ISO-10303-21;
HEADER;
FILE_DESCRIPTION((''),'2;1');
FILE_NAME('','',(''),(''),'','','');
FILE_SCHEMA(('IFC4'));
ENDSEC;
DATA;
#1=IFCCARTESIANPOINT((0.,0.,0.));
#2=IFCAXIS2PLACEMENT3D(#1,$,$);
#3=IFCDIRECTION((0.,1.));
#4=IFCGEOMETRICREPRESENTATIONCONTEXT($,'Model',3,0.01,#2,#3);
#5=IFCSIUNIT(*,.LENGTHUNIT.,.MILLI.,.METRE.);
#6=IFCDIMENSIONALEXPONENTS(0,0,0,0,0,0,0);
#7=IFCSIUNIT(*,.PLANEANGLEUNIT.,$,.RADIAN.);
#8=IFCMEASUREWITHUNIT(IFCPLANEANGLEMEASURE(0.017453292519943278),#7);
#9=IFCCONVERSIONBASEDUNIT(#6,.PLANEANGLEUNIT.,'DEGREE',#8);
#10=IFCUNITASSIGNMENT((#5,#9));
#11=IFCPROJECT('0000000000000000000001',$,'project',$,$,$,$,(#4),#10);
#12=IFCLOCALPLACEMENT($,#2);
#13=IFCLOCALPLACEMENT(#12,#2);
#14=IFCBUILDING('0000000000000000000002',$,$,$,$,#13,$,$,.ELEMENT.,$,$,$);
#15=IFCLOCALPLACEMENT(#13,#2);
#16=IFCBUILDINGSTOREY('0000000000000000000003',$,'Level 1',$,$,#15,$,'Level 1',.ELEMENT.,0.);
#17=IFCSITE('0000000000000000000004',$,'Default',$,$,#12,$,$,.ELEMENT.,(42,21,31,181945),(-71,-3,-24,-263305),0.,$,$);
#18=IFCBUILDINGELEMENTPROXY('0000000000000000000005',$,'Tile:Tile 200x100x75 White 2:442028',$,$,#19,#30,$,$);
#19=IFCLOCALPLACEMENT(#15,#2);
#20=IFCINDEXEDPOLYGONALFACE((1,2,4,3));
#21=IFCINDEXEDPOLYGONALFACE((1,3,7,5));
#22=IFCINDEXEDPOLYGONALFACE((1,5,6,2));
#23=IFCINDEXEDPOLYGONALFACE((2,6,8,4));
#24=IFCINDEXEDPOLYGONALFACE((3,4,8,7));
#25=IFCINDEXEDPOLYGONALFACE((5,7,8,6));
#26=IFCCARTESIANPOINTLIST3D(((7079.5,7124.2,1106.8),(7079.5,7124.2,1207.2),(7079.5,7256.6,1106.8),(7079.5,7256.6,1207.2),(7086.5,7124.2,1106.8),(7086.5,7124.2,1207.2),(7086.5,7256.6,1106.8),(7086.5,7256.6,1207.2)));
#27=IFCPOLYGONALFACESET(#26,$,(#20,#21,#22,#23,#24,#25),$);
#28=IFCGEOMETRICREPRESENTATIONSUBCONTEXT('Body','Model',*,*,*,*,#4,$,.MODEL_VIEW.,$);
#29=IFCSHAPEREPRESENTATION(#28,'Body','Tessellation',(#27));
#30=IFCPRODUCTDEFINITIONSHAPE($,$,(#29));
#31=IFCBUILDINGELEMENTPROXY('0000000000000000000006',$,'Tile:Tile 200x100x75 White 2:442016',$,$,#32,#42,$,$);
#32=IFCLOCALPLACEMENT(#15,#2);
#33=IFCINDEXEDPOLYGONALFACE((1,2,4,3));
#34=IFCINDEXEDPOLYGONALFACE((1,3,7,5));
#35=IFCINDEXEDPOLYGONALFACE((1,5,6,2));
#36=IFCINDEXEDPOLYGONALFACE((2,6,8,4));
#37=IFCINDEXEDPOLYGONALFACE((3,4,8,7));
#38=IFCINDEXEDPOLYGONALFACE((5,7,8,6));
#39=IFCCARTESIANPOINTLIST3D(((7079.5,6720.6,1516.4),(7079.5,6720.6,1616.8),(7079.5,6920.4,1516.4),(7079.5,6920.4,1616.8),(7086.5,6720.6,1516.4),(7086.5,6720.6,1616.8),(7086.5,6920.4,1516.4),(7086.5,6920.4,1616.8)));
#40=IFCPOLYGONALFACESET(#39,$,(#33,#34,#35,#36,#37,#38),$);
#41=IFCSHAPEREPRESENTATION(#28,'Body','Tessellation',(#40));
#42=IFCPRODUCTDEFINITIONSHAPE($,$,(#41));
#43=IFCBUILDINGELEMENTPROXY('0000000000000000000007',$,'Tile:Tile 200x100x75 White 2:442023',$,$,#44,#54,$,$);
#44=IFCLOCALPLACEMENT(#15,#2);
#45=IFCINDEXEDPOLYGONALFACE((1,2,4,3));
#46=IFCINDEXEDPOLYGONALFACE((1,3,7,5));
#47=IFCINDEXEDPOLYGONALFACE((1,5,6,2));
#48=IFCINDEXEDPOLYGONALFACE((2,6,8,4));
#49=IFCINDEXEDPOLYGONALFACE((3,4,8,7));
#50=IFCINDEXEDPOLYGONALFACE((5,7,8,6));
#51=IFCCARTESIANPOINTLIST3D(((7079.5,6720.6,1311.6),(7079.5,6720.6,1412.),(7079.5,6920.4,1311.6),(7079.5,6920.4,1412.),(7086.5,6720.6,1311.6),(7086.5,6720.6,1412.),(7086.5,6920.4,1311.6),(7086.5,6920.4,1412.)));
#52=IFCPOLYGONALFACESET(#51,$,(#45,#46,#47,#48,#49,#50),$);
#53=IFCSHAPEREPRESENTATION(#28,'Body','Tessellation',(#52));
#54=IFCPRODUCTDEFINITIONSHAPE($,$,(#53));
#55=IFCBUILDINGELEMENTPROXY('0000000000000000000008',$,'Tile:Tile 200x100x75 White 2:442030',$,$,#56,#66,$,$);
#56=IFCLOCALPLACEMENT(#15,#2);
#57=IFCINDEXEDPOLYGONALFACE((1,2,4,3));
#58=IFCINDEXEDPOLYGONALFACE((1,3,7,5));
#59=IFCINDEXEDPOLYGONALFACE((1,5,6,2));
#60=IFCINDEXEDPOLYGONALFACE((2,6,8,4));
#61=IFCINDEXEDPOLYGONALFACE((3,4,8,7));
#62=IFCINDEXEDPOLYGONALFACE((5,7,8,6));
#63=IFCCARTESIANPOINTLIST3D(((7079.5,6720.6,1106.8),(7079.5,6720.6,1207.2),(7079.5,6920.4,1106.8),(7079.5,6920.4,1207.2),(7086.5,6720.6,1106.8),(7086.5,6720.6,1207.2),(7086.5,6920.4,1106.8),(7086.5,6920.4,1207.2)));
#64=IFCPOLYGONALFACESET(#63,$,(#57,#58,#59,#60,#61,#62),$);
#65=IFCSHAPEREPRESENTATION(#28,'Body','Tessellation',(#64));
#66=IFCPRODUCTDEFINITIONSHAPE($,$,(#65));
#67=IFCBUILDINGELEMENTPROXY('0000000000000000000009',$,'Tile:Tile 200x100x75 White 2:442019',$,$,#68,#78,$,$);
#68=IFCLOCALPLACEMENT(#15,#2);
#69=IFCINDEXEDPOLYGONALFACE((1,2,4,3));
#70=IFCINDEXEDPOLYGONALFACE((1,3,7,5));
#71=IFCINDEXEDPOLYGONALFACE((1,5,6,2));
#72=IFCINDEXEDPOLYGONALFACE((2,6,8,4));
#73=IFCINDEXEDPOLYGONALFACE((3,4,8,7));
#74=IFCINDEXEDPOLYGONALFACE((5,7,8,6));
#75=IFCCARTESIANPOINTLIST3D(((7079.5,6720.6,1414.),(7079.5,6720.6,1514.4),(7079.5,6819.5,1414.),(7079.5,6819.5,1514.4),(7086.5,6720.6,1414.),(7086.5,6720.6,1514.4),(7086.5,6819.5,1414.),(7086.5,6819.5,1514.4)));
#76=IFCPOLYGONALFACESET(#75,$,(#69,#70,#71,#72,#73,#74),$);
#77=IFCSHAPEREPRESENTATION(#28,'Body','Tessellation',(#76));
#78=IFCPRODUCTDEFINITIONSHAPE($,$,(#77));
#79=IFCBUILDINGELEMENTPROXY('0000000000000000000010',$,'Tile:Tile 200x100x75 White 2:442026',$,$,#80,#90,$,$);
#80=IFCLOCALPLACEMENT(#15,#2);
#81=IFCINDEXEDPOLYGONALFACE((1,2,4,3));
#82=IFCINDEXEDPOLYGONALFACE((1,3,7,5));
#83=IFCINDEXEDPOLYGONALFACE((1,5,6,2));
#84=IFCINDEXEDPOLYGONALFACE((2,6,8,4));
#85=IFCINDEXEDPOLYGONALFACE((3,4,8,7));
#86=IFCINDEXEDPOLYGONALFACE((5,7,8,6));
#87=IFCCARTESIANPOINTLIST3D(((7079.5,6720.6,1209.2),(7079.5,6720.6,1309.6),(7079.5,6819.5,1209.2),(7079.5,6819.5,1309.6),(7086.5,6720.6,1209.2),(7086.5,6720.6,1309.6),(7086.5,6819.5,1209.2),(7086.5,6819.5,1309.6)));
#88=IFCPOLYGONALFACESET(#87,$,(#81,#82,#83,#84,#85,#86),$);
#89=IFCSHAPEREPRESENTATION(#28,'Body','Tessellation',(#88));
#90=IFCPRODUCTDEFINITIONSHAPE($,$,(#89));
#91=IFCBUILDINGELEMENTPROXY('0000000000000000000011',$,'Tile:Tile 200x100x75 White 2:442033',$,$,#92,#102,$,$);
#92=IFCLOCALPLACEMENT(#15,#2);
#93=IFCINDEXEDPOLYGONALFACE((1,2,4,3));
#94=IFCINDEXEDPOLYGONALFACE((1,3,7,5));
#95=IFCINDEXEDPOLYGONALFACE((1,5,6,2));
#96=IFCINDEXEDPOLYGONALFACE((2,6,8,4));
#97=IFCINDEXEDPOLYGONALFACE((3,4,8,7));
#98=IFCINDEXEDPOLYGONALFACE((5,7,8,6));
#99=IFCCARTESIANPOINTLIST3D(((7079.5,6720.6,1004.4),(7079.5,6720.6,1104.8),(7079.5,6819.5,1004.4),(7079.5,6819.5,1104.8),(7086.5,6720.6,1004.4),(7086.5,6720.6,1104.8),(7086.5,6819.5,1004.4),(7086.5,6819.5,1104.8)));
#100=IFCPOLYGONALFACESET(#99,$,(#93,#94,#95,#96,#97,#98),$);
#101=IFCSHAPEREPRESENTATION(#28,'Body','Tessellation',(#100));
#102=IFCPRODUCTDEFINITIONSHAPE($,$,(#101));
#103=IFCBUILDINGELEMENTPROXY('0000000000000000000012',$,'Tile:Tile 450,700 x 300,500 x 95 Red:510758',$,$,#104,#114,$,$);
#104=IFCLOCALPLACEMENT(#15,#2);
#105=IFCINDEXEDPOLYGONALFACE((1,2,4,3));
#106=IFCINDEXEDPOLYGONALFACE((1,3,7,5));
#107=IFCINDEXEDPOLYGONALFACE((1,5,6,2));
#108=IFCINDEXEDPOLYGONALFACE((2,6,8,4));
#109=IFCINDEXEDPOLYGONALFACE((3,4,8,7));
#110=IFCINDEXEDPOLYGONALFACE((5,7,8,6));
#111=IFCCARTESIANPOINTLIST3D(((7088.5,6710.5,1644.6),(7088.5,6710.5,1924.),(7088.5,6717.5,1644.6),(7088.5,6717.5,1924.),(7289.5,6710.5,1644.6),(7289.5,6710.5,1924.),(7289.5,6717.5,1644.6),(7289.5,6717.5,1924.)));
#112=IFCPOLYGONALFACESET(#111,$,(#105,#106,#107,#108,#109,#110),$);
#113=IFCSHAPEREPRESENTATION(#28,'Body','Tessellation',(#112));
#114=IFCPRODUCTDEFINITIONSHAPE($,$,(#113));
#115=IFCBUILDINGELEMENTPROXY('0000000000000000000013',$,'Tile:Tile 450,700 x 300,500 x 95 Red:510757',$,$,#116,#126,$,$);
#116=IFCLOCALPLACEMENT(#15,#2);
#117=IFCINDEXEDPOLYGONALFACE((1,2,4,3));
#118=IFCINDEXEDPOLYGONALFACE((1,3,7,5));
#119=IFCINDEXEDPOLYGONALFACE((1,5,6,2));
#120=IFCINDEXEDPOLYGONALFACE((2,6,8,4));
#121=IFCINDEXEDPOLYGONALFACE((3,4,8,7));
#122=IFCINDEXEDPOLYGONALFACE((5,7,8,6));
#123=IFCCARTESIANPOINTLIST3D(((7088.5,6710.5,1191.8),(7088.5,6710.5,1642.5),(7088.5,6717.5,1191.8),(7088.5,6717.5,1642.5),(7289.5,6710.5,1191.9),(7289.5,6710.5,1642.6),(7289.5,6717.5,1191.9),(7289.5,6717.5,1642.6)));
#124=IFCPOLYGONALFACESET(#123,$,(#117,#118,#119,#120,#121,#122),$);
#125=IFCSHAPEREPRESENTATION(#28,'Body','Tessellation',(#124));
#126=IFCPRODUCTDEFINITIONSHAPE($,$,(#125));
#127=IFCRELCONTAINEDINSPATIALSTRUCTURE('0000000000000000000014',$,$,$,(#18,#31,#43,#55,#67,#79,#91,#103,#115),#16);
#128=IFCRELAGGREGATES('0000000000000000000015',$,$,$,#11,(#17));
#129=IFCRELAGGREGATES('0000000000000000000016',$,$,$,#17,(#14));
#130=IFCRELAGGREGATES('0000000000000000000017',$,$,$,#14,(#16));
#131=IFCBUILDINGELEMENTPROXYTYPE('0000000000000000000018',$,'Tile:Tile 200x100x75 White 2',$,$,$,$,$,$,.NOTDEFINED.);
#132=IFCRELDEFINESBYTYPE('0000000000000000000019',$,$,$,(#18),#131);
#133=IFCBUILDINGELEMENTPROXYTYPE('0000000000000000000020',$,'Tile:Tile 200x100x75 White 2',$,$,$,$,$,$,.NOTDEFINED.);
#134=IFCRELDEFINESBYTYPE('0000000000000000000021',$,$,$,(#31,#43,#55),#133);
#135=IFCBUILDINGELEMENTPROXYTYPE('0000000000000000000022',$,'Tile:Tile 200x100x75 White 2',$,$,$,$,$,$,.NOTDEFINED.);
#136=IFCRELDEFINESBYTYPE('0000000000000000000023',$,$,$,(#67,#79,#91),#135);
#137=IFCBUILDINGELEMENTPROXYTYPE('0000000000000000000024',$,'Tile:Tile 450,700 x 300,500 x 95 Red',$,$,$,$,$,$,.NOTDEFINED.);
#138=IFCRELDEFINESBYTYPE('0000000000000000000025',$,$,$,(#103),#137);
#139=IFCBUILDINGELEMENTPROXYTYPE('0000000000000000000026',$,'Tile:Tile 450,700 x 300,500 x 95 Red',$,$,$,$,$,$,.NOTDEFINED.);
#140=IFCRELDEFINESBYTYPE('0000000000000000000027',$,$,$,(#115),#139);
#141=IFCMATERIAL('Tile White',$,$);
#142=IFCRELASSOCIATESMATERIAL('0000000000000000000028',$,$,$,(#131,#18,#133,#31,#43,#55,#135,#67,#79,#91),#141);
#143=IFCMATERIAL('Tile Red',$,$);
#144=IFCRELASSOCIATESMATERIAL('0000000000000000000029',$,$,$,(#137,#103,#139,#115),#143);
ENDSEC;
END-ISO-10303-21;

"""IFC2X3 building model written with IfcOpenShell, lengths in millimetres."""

from ifc_helpers import new_model, entity, si_unit, converted_unit, direction, frame, frame_2d, origin, origin_2d_with_axis, place, context, subcontext, project, spatial, rectangle, extrude, source, transform, mapped, material, type_object, type_shapes, element, save


model = new_model("IFC2X3")

# Units and contexts
model_context = context("Model", 3, precision=0.01, world=origin(), true_north=direction((0.0, 1.0)))
body_context = subcontext(model_context, "Body", "Model", "MODEL_VIEW")
ifc_project = project(units=[si_unit("LENGTHUNIT", "METRE", prefix="MILLI"), converted_unit("PLANEANGLEUNIT", "DEGREE", entity("IfcPlaneAngleMeasure", 0.017453292519943278), si_unit("PLANEANGLEUNIT", "RADIAN"), dimensions=[0, 0, 0, 0, 0, 0, 0])], contexts=[model_context])

# Site, building, storey
site_placement = place(None, origin())
site = spatial("IfcSite", under=ifc_project, at=site_placement, Name="Default", CompositionType="ELEMENT", RefLatitude=(42, 21, 31, 181945), RefLongitude=(-71, -3, -24, -263305), RefElevation=0.0)
building_placement = place(site_placement, origin())
building = spatial("IfcBuilding", under=site, at=building_placement, CompositionType="ELEMENT")
storey_placement = place(building_placement, origin())
storey = spatial("IfcBuildingStorey", under=building, at=storey_placement, Name="Level 1", LongName="Level 1", CompositionType="ELEMENT", Elevation=0.0)

# Building element proxies
ifc_material_1 = material(Name="Tile White")
building_element_proxy_type_1 = type_object("IfcBuildingElementProxyType", Name="Tile:Tile 200x100x75 White 2", PredefinedType="NOTDEFINED", material=ifc_material_1)
shared_shape_1 = source(origin(), body_context, "Body", "SweptSolid", [
    extrude(rectangle(XDim=100.4, YDim=132.4, at=frame_2d((0.0, 0.0), x_axis=(1.0, 0.0))), frame((-50.2, 66.2, 0.0)), (0.0, 0.0, 1.0), 7.0),
])
type_shapes(building_element_proxy_type_1, [shared_shape_1])
for number, where, z_axis, x_axis, name in (
    (1, (7086.5, 7124.2, 1207.2), (-1.0, 0.0, 0.0), (0.0, 0.0, 1.0), "Tile:Tile 200x100x75 White 2:442028"),
):
    element("IfcBuildingElementProxy", number, at=place(storey_placement, frame(where, z_axis=z_axis, x_axis=x_axis)), inside=storey, type_object=building_element_proxy_type_1, material=ifc_material_1, Name=name, context=body_context, shape_type="MappedRepresentation", body=[
        mapped(shared_shape_1, transform((0.0, 0.0, 0.0), scale=1.0)),
    ])
building_element_proxy_type_2 = type_object("IfcBuildingElementProxyType", Name="Tile:Tile 200x100x75 White 2", PredefinedType="NOTDEFINED", material=ifc_material_1)
shared_shape_2 = source(origin(), body_context, "Body", "SweptSolid", [
    extrude(rectangle(XDim=100.4, YDim=199.8, at=origin_2d_with_axis()), frame((-50.2, 99.9, 0.0)), (0.0, 0.0, 1.0), 7.0),
])
type_shapes(building_element_proxy_type_2, [shared_shape_2])
for number, where, z_axis, x_axis, name in (
    (2, (7086.5, 6720.6, 1616.8), (-1.0, 0.0, 0.0), (0.0, 0.0, 1.0), "Tile:Tile 200x100x75 White 2:442016"),
    (3, (7086.5, 6720.6, 1412.0), (-1.0, 0.0, 0.0), (0.0, 0.0, 1.0), "Tile:Tile 200x100x75 White 2:442023"),
    (4, (7086.5, 6720.6, 1207.2), (-1.0, 0.0, 0.0), (0.0, 0.0, 1.0), "Tile:Tile 200x100x75 White 2:442030"),
):
    element("IfcBuildingElementProxy", number, at=place(storey_placement, frame(where, z_axis=z_axis, x_axis=x_axis)), inside=storey, type_object=building_element_proxy_type_2, material=ifc_material_1, Name=name, context=body_context, shape_type="MappedRepresentation", body=[
        mapped(shared_shape_2, transform((0.0, 0.0, 0.0), scale=1.0)),
    ])
building_element_proxy_type_3 = type_object("IfcBuildingElementProxyType", Name="Tile:Tile 200x100x75 White 2", PredefinedType="NOTDEFINED", material=ifc_material_1)
shared_shape_3 = source(origin(), body_context, "Body", "SweptSolid", [
    extrude(rectangle(XDim=100.4, YDim=98.9, at=origin_2d_with_axis()), frame((-50.2, 49.5, 0.0)), (0.0, 0.0, 1.0), 7.0),
])
type_shapes(building_element_proxy_type_3, [shared_shape_3])
for number, where, z_axis, x_axis, name in (
    (5, (7086.5, 6720.6, 1514.4), (-1.0, 0.0, 0.0), (0.0, 0.0, 1.0), "Tile:Tile 200x100x75 White 2:442019"),
    (6, (7086.5, 6720.6, 1309.6), (-1.0, 0.0, 0.0), (0.0, 0.0, 1.0), "Tile:Tile 200x100x75 White 2:442026"),
    (7, (7086.5, 6720.6, 1104.8), (-1.0, 0.0, 0.0), (0.0, 0.0, 1.0), "Tile:Tile 200x100x75 White 2:442033"),
):
    element("IfcBuildingElementProxy", number, at=place(storey_placement, frame(where, z_axis=z_axis, x_axis=x_axis)), inside=storey, type_object=building_element_proxy_type_3, material=ifc_material_1, Name=name, context=body_context, shape_type="MappedRepresentation", body=[
        mapped(shared_shape_3, transform((0.0, 0.0, 0.0), scale=1.0)),
    ])
ifc_material_2 = material(Name="Tile Red")
building_element_proxy_type_4 = type_object("IfcBuildingElementProxyType", Name="Tile:Tile 450,700 x 300,500 x 95 Red", PredefinedType="NOTDEFINED", material=ifc_material_2)
shared_shape_4 = source(origin(), body_context, "Body", "SweptSolid", [
    extrude(rectangle(XDim=201.0, YDim=279.5, at=frame_2d((0.0, 0.0), x_axis=(1.0, 0.0))), frame((-100.5, -139.7, 0.0), z_axis=(0.0, 0.0, 1.0), x_axis=(-1.0, 0.0, 0.0)), (0.0, 0.0, 1.0), 7.0),
])
type_shapes(building_element_proxy_type_4, [shared_shape_4])
proxy_1_placement = place(storey_placement, frame((7088.5, 6717.5, 1644.6), z_axis=(0.0, -1.0, 0.0), x_axis=(-1.0, 0.0, 0.0)))
element("IfcBuildingElementProxy", 8, at=proxy_1_placement, inside=storey, type_object=building_element_proxy_type_4, material=ifc_material_2, Name="Tile:Tile 450,700 x 300,500 x 95 Red:510758", context=body_context, shape_type="MappedRepresentation", body=[
    mapped(shared_shape_4, transform((0.0, 0.0, 0.0), scale=1.0)),
])
building_element_proxy_type_5 = type_object("IfcBuildingElementProxyType", Name="Tile:Tile 450,700 x 300,500 x 95 Red", PredefinedType="NOTDEFINED", material=ifc_material_2)
shared_shape_5 = source(origin(), body_context, "Body", "SweptSolid", [
    extrude(rectangle(XDim=201.0, YDim=450.7, at=frame_2d((0.0, 0.0), x_axis=(1.0, 0.0))), frame((-100.5, -225.4, 0.0), z_axis=(0.0, 0.0, 1.0), x_axis=(-1.0, 0.0, 0.0)), (0.0, 0.0, 1.0), 7.0),
])
type_shapes(building_element_proxy_type_5, [shared_shape_5])
proxy_2_placement = place(storey_placement, frame((7088.5, 6717.5, 1191.8), z_axis=(0.0, -1.0, 0.0), x_axis=(-1.0, 0.0, -0.000041)))
element("IfcBuildingElementProxy", 9, at=proxy_2_placement, inside=storey, type_object=building_element_proxy_type_5, material=ifc_material_2, Name="Tile:Tile 450,700 x 300,500 x 95 Red:510757", context=body_context, shape_type="MappedRepresentation", body=[
    mapped(shared_shape_5, transform((0.0, 0.0, 0.0), scale=1.0)),
])

save(model, "model.ifc")
